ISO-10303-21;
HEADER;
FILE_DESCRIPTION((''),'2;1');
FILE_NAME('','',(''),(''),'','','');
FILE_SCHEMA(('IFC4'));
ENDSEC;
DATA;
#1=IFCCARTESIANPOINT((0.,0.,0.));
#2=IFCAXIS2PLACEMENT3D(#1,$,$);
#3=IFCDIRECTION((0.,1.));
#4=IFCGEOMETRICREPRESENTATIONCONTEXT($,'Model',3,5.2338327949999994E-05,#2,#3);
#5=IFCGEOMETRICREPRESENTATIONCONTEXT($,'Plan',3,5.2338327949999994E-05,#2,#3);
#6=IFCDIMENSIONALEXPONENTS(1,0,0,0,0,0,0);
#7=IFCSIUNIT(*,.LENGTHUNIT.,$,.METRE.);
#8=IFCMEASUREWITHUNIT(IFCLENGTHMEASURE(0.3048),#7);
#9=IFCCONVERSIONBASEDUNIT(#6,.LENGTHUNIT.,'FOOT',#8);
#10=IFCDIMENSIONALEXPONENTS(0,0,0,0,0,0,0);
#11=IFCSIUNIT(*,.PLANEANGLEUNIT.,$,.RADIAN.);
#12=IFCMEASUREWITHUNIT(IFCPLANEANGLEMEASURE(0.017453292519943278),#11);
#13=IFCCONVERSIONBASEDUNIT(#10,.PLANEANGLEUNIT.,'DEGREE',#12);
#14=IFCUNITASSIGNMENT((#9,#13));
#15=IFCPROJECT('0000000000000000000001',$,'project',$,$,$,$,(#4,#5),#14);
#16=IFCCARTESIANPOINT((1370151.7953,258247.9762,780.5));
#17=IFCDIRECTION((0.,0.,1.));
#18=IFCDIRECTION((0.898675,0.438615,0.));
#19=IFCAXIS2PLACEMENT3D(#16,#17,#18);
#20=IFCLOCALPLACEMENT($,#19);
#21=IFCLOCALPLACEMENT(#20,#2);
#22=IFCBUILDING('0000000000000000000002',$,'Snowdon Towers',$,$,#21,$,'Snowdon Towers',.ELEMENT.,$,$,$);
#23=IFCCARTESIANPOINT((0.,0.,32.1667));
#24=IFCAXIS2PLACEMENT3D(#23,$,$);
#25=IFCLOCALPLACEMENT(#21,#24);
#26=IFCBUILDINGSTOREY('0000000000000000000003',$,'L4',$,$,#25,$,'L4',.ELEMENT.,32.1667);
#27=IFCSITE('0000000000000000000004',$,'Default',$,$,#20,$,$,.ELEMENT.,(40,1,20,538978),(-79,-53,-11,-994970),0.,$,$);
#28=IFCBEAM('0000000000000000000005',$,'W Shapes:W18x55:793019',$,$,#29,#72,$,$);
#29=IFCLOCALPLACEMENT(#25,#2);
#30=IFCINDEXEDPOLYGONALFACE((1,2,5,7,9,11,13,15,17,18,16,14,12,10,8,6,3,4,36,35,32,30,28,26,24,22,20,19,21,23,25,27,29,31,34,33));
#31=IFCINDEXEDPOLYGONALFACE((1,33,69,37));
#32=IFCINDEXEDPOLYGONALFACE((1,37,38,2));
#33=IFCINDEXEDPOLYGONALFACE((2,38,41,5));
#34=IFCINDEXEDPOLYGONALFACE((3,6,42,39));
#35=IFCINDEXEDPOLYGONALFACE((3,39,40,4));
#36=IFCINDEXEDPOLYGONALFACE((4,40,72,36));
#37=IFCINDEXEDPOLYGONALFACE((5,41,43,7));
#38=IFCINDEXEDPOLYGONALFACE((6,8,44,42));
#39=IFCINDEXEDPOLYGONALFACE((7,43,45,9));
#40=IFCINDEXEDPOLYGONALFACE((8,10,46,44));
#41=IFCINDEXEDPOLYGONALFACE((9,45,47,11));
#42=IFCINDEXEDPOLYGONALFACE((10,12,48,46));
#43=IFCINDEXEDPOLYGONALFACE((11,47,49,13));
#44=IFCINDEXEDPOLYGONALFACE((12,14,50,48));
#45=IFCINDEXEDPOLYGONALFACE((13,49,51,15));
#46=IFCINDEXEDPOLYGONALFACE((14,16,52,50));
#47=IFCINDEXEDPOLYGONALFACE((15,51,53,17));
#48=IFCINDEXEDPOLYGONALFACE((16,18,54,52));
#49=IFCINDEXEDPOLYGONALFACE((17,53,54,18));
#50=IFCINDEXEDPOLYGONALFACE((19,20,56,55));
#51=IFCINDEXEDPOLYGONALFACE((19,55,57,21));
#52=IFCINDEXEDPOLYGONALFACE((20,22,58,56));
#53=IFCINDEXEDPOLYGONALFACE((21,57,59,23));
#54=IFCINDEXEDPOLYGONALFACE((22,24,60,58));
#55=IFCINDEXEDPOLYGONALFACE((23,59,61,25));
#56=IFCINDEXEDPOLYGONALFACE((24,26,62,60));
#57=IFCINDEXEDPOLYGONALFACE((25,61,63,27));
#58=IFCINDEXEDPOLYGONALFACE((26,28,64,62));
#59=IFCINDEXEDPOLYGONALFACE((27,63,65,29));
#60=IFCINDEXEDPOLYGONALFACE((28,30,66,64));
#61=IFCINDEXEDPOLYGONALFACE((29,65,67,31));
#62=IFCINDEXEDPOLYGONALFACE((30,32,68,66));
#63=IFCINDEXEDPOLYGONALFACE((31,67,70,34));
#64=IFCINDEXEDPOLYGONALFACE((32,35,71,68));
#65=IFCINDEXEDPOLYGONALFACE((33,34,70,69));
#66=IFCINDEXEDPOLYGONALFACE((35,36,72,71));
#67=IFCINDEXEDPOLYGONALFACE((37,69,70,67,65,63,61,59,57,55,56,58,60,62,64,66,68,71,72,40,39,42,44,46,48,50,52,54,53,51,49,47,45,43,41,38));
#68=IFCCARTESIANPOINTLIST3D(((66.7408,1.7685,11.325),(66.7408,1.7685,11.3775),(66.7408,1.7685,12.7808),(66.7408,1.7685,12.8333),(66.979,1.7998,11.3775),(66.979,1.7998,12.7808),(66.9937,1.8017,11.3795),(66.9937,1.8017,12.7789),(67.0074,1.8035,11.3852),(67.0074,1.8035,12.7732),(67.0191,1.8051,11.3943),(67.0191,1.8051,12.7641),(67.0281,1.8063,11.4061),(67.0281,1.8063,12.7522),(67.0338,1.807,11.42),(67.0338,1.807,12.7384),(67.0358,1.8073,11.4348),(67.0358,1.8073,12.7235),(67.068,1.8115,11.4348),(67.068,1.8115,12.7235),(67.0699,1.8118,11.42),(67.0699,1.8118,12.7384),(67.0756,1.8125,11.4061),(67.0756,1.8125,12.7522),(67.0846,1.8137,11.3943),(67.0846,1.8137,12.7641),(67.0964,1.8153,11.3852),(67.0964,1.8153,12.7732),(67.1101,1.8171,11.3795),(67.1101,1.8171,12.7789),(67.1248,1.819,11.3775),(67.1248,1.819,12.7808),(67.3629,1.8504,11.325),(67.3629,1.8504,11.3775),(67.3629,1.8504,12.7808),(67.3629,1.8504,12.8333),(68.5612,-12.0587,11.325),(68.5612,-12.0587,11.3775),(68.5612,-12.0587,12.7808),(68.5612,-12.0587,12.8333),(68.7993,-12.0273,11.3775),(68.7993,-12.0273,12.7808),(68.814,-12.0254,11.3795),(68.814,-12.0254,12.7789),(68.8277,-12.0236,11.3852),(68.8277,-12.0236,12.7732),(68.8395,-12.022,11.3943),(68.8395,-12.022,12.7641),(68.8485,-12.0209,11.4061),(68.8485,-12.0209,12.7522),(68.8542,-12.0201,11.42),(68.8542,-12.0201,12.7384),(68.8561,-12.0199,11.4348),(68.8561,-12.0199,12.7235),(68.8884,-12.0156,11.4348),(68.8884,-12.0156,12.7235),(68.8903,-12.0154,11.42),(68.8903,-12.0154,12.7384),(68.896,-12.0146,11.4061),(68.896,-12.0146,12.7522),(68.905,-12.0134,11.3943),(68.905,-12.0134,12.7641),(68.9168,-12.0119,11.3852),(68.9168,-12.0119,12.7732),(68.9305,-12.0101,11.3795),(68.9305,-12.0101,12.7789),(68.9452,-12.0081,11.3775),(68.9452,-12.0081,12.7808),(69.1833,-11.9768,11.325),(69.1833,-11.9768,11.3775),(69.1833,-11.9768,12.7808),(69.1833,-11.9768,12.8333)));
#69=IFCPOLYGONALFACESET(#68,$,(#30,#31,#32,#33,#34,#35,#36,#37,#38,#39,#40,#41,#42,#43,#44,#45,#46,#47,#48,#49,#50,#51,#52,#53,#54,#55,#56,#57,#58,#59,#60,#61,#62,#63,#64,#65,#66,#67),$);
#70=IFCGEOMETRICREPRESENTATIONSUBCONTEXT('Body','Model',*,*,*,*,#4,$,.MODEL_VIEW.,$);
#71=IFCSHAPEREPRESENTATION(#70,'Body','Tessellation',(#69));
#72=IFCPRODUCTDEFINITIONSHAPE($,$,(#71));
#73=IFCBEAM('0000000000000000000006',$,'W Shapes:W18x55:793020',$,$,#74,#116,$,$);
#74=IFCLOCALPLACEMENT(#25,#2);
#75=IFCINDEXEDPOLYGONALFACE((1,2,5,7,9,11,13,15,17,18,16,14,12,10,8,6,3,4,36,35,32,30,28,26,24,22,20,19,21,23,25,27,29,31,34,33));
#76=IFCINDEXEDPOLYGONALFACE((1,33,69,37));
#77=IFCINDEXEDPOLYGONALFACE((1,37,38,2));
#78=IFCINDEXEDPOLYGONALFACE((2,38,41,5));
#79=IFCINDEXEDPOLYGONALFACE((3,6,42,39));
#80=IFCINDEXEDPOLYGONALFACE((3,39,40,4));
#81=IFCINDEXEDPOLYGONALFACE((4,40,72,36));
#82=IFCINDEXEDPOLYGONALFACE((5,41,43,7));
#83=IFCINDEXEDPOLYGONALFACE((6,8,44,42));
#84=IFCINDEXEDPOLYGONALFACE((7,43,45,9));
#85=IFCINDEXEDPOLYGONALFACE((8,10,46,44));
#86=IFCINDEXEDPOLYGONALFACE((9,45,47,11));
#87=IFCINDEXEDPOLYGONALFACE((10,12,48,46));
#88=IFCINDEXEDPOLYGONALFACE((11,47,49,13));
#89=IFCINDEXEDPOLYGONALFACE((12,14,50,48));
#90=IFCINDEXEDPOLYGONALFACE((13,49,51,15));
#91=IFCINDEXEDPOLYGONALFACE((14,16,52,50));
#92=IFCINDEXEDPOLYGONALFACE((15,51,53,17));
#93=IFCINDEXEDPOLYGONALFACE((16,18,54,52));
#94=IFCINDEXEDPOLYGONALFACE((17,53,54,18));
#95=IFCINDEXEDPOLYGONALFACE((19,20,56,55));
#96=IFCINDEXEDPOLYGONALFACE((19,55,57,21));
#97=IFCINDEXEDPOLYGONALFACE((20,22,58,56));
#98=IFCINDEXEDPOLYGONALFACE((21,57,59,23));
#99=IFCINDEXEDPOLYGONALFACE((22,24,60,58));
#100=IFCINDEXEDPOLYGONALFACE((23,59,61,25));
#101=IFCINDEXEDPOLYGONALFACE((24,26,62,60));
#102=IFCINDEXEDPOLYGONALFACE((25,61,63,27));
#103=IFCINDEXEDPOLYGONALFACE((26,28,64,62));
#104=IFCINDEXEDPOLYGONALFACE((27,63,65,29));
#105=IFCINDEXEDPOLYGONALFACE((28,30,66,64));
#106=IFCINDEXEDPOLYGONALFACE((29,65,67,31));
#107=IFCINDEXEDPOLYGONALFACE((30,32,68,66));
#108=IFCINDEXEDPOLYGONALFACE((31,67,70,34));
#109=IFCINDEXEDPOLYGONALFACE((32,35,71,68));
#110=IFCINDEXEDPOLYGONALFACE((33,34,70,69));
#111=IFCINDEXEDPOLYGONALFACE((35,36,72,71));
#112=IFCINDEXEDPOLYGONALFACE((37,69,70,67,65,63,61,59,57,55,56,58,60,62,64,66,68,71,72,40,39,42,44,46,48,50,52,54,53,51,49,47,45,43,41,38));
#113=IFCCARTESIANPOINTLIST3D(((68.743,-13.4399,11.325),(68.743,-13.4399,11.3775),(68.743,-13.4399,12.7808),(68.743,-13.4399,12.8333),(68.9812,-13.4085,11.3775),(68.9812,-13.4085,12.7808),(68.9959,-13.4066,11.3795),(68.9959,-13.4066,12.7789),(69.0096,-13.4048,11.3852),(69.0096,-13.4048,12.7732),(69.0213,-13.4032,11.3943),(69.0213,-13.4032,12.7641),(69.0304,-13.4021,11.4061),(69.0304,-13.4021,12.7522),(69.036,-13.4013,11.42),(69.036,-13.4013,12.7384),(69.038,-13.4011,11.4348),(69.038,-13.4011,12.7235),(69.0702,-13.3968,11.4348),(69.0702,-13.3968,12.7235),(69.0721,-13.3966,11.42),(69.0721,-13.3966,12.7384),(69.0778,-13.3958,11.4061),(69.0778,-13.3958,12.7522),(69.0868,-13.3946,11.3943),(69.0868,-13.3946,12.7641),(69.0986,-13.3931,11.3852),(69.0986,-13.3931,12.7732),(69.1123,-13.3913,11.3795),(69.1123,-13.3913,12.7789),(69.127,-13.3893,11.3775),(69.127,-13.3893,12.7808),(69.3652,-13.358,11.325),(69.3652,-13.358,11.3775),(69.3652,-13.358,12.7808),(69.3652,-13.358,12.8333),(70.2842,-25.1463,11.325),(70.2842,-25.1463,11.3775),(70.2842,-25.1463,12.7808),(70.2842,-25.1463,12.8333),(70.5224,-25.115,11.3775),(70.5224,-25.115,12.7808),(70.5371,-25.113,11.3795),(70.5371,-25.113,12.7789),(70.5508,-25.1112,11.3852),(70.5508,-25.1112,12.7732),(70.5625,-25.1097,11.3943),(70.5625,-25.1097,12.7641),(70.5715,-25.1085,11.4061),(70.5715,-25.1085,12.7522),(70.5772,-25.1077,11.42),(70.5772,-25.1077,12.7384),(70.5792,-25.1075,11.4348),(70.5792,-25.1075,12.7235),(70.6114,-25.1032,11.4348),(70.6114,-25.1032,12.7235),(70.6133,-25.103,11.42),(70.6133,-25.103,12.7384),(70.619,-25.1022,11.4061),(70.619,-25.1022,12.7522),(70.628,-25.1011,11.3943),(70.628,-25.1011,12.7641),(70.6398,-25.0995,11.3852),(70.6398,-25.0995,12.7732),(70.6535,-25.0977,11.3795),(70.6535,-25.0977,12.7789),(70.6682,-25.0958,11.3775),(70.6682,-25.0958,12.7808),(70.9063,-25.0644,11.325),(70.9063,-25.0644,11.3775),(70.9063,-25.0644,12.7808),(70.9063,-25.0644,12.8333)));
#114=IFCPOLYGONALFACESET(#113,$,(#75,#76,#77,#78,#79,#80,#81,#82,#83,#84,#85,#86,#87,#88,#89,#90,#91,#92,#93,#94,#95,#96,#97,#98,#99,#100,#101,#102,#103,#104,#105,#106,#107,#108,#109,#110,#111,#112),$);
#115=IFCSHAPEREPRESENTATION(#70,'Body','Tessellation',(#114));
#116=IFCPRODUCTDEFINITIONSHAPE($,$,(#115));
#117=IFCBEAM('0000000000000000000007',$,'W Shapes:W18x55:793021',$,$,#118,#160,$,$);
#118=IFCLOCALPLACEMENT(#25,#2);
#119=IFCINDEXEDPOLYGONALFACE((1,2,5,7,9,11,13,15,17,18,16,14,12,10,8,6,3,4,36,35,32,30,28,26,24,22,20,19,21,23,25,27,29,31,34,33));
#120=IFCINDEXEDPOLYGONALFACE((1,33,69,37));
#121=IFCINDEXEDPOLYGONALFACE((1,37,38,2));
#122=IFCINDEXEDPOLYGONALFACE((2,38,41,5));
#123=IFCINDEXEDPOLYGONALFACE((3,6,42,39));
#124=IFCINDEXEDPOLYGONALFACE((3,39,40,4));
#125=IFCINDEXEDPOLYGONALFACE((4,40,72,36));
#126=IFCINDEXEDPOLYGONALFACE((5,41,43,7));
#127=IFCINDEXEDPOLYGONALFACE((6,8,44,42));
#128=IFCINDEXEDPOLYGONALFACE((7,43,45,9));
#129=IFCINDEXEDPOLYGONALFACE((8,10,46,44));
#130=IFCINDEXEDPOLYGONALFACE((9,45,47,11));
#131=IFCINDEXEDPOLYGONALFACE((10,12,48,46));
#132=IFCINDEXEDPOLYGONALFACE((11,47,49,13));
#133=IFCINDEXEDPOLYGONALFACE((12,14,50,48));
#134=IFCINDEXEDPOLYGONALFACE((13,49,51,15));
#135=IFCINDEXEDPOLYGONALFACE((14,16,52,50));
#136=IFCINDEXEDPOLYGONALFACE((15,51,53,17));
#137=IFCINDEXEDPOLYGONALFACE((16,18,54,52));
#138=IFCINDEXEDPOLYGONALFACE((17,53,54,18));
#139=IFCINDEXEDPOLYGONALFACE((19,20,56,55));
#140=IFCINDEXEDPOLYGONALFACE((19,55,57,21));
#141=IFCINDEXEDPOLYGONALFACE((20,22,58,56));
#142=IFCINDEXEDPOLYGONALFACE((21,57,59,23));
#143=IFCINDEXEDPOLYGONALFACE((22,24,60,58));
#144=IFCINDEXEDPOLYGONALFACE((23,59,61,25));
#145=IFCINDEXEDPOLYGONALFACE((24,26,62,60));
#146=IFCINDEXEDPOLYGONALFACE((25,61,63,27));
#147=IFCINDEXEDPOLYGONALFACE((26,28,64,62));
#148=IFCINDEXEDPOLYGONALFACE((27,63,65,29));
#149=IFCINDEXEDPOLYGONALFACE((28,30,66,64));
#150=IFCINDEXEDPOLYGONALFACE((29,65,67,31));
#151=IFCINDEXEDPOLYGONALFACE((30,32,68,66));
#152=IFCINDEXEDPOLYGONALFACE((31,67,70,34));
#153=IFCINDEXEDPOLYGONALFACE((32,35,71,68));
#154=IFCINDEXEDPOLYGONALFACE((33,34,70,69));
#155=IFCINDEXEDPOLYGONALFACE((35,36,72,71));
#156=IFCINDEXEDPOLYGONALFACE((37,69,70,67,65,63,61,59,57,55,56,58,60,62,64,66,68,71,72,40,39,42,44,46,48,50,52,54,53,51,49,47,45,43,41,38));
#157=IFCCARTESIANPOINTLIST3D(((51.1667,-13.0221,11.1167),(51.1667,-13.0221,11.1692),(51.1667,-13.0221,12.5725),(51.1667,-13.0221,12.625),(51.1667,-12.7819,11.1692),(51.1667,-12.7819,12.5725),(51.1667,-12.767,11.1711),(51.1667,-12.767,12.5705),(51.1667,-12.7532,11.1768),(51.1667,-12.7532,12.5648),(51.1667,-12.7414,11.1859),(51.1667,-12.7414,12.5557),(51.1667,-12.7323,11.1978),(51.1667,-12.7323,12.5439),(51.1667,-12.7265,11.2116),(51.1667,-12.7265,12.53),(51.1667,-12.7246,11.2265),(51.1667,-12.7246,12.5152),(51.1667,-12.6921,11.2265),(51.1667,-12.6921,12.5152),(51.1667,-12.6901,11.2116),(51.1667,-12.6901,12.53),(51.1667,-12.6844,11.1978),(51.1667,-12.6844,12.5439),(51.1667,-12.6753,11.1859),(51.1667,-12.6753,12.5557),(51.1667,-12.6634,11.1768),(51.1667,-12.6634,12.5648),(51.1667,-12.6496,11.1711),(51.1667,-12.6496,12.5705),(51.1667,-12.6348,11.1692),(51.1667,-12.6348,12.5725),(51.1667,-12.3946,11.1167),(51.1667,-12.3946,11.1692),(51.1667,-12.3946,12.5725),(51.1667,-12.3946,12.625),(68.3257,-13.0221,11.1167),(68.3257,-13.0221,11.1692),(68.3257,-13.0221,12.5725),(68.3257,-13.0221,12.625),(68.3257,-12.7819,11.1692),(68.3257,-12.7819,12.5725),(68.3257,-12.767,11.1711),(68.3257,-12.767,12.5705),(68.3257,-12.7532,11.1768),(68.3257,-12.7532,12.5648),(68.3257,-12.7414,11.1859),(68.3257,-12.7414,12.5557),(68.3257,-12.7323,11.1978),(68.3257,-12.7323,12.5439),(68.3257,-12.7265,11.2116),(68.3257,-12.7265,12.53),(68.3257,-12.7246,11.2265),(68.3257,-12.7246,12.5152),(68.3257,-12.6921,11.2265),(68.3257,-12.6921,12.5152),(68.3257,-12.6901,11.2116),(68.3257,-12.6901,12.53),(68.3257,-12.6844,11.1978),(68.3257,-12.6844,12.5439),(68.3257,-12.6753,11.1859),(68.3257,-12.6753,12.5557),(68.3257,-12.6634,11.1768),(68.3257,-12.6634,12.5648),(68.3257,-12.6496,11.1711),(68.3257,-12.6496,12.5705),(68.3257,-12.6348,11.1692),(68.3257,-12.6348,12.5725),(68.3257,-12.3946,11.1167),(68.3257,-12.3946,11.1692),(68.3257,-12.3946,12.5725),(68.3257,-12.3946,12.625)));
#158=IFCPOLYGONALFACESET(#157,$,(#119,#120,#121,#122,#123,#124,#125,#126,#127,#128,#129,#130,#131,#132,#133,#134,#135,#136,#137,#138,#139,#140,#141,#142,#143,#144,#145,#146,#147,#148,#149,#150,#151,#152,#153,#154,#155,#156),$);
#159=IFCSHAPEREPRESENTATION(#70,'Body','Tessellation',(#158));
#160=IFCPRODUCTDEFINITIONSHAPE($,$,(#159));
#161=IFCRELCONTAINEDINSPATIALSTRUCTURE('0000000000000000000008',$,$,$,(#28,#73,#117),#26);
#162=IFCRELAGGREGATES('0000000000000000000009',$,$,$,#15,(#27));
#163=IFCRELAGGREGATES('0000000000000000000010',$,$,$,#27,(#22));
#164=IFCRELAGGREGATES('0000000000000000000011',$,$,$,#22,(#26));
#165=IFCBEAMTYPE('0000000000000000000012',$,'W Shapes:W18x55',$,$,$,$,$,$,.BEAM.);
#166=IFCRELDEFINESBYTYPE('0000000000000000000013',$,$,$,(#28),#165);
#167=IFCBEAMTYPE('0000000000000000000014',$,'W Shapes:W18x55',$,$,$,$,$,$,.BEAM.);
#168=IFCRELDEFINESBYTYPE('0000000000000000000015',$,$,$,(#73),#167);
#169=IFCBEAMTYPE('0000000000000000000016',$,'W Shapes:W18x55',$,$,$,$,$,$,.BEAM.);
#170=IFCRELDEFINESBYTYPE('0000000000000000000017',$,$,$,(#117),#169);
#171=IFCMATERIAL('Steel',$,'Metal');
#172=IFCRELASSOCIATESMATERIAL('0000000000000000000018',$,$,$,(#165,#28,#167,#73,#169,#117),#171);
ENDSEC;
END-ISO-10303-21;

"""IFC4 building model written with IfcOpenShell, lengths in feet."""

from ifc_helpers import new_model, entity, si_unit, converted_unit, direction, frame, origin, place, context, subcontext, project, spatial, line, arc, indexed_curve, outline, extrude, source, transform, mapped, material, type_object, type_shapes, element, save


model = new_model("IFC4")

# Units and contexts
model_context = context("Model", 3, precision=5.2338327949999994e-05, world=origin(), true_north=direction((0.0, 1.0)))
plan_context = context("Plan", 3, precision=5.2338327949999994e-05, world=origin(), true_north=direction((0.0, 1.0)))
body_context = subcontext(model_context, "Body", "Model", "MODEL_VIEW")
ifc_project = project(units=[converted_unit("LENGTHUNIT", "FOOT", entity("IfcLengthMeasure", 0.3048), si_unit("LENGTHUNIT", "METRE"), dimensions=[1, 0, 0, 0, 0, 0, 0]), converted_unit("PLANEANGLEUNIT", "DEGREE", entity("IfcPlaneAngleMeasure", 0.017453292519943278), si_unit("PLANEANGLEUNIT", "RADIAN"), dimensions=[0, 0, 0, 0, 0, 0, 0])], contexts=[model_context, plan_context])

# Site, building, storey
site_placement = place(None, frame((1370151.7953, 258247.9762, 780.5), z_axis=(0.0, 0.0, 1.0), x_axis=(0.898675, 0.438615, 0.0)))
site = spatial("IfcSite", under=ifc_project, at=site_placement, Name="Default", CompositionType="ELEMENT", RefLatitude=(40, 1, 20, 538978), RefLongitude=(-79, -53, -11, -994970), RefElevation=0.0)
building_placement = place(site_placement, origin())
building = spatial("IfcBuilding", under=site, at=building_placement, Name="Snowdon Towers", LongName="Snowdon Towers", CompositionType="ELEMENT")
storey_placement = place(building_placement, frame((0.0, 0.0, 32.1667)))
storey = spatial("IfcBuildingStorey", under=building, at=storey_placement, Name="L4", LongName="L4", CompositionType="ELEMENT", Elevation=32.1667)

# Beams
ifc_material = material(Name="Steel", Category="Metal")
beam_type_1 = type_object("IfcBeamType", Name="W Shapes:W18x55", PredefinedType="BEAM", material=ifc_material)
shared_shape_1 = source(origin(), body_context, "Body", "SweptSolid", [
    extrude(outline(indexed_curve([(-0.7542, -0.3138), (-0.7017, -0.3138), (-0.7017, -0.0735), (-0.6849, -0.033), (-0.6444, -0.0162), (0.6444, -0.0162), (0.6849, -0.033), (0.7017, -0.0735), (0.7017, -0.3138), (0.7542, -0.3138), (0.7542, 0.3138), (0.7017, 0.3138), (0.7017, 0.0735), (0.6849, 0.033), (0.6444, 0.0163), (-0.6444, 0.0163), (-0.6849, 0.033), (-0.7017, 0.0735), (-0.7017, 0.3137), (-0.7542, 0.3137)], segments=[line(1, 2, 3), arc(3, 4, 5), line(5, 6), arc(6, 7, 8), line(8, 9, 10, 11, 12, 13), arc(13, 14, 15), line(15, 16), arc(16, 17, 18), line(18, 19, 20, 1)], self_intersect=False)), frame((-7.05, 0.0, 0.0), z_axis=(1.0, 0.0, 0.0), x_axis=(0.0, 0.0, -1.0)), (0.0, 0.0, 1.0), 13.9465),
])
type_shapes(beam_type_1, [shared_shape_1])
beam_1_placement = place(storey_placement, frame((67.9721, -5.1803, 12.0792), z_axis=(0.0, 0.0, 1.0), x_axis=(0.130526, -0.991445, 0.0)))
element("IfcBeam", 1, at=beam_1_placement, inside=storey, type_object=beam_type_1, material=ifc_material, Name="W Shapes:W18x55:793019", context=body_context, shape_type="MappedRepresentation", body=[
    mapped(shared_shape_1, transform((0.0, 0.0, 0.0), scale=1.0)),
])
beam_type_2 = type_object("IfcBeamType", Name="W Shapes:W18x55", PredefinedType="BEAM", material=ifc_material)
shared_shape_2 = source(origin(), body_context, "Body", "SweptSolid", [
    extrude(outline(indexed_curve([(-0.7542, -0.3138), (-0.7017, -0.3138), (-0.7017, -0.0735), (-0.6849, -0.033), (-0.6444, -0.0162), (0.6444, -0.0162), (0.6849, -0.033), (0.7017, -0.0735), (0.7017, -0.3138), (0.7542, -0.3138), (0.7542, 0.3138), (0.7017, 0.3138), (0.7017, 0.0735), (0.6849, 0.033), (0.6444, 0.0163), (-0.6444, 0.0163), (-0.6849, 0.033), (-0.7017, 0.0735), (-0.7017, 0.3137), (-0.7542, 0.3137)], segments=[line(1, 2, 3), arc(3, 4, 5), line(5, 6), arc(6, 7, 8), line(8, 9, 10, 11, 12, 13), arc(13, 14, 15), line(15, 16), arc(16, 17, 18), line(18, 19, 20, 1)], self_intersect=False)), frame((-5.9188, 0.0, 0.0), z_axis=(1.0, 0.0, 0.0), x_axis=(0.0, 0.0, -1.0)), (0.0, 0.0, 1.0), 11.8075),
])
type_shapes(beam_type_2, [shared_shape_2])
beam_2_placement = place(storey_placement, frame((69.8266, -19.2671, 12.0792), z_axis=(0.0, 0.0, 1.0), x_axis=(0.130526, -0.991445, 0.0)))
element("IfcBeam", 2, at=beam_2_placement, inside=storey, type_object=beam_type_2, material=ifc_material, Name="W Shapes:W18x55:793020", context=body_context, shape_type="MappedRepresentation", body=[
    mapped(shared_shape_2, transform((0.0, 0.0, 0.0), scale=1.0)),
])
beam_type_3 = type_object("IfcBeamType", Name="W Shapes:W18x55", PredefinedType="BEAM", material=ifc_material)
shared_shape_3 = source(origin(), body_context, "Body", "SweptSolid", [
    extrude(outline(indexed_curve([(-0.7542, -0.3138), (-0.7017, -0.3138), (-0.7017, -0.0735), (-0.6849, -0.033), (-0.6444, -0.0162), (0.6444, -0.0162), (0.6849, -0.033), (0.7017, -0.0735), (0.7017, -0.3138), (0.7542, -0.3138), (0.7542, 0.3138), (0.7017, 0.3138), (0.7017, 0.0735), (0.6849, 0.033), (0.6444, 0.0163), (-0.6444, 0.0163), (-0.6849, 0.033), (-0.7017, 0.0735), (-0.7017, 0.3137), (-0.7542, 0.3137)], segments=[line(1, 2, 3), arc(3, 4, 5), line(5, 6), arc(6, 7, 8), line(8, 9, 10, 11, 12, 13), arc(13, 14, 15), line(15, 16), arc(16, 17, 18), line(18, 19, 20, 1)], self_intersect=False)), frame((-8.9216, 0.0, 0.0), z_axis=(1.0, 0.0, 0.0), x_axis=(0.0, 0.0, -1.0)), (0.0, 0.0, 1.0), 17.159),
])
type_shapes(beam_type_3, [shared_shape_3])
beam_3_placement = place(storey_placement, frame((60.0883, -12.7083, 11.8708)))
element("IfcBeam", 3, at=beam_3_placement, inside=storey, type_object=beam_type_3, material=ifc_material, Name="W Shapes:W18x55:793021", context=body_context, shape_type="MappedRepresentation", body=[
    mapped(shared_shape_3, transform((0.0, 0.0, 0.0), scale=1.0)),
])

save(model, "model.ifc")
